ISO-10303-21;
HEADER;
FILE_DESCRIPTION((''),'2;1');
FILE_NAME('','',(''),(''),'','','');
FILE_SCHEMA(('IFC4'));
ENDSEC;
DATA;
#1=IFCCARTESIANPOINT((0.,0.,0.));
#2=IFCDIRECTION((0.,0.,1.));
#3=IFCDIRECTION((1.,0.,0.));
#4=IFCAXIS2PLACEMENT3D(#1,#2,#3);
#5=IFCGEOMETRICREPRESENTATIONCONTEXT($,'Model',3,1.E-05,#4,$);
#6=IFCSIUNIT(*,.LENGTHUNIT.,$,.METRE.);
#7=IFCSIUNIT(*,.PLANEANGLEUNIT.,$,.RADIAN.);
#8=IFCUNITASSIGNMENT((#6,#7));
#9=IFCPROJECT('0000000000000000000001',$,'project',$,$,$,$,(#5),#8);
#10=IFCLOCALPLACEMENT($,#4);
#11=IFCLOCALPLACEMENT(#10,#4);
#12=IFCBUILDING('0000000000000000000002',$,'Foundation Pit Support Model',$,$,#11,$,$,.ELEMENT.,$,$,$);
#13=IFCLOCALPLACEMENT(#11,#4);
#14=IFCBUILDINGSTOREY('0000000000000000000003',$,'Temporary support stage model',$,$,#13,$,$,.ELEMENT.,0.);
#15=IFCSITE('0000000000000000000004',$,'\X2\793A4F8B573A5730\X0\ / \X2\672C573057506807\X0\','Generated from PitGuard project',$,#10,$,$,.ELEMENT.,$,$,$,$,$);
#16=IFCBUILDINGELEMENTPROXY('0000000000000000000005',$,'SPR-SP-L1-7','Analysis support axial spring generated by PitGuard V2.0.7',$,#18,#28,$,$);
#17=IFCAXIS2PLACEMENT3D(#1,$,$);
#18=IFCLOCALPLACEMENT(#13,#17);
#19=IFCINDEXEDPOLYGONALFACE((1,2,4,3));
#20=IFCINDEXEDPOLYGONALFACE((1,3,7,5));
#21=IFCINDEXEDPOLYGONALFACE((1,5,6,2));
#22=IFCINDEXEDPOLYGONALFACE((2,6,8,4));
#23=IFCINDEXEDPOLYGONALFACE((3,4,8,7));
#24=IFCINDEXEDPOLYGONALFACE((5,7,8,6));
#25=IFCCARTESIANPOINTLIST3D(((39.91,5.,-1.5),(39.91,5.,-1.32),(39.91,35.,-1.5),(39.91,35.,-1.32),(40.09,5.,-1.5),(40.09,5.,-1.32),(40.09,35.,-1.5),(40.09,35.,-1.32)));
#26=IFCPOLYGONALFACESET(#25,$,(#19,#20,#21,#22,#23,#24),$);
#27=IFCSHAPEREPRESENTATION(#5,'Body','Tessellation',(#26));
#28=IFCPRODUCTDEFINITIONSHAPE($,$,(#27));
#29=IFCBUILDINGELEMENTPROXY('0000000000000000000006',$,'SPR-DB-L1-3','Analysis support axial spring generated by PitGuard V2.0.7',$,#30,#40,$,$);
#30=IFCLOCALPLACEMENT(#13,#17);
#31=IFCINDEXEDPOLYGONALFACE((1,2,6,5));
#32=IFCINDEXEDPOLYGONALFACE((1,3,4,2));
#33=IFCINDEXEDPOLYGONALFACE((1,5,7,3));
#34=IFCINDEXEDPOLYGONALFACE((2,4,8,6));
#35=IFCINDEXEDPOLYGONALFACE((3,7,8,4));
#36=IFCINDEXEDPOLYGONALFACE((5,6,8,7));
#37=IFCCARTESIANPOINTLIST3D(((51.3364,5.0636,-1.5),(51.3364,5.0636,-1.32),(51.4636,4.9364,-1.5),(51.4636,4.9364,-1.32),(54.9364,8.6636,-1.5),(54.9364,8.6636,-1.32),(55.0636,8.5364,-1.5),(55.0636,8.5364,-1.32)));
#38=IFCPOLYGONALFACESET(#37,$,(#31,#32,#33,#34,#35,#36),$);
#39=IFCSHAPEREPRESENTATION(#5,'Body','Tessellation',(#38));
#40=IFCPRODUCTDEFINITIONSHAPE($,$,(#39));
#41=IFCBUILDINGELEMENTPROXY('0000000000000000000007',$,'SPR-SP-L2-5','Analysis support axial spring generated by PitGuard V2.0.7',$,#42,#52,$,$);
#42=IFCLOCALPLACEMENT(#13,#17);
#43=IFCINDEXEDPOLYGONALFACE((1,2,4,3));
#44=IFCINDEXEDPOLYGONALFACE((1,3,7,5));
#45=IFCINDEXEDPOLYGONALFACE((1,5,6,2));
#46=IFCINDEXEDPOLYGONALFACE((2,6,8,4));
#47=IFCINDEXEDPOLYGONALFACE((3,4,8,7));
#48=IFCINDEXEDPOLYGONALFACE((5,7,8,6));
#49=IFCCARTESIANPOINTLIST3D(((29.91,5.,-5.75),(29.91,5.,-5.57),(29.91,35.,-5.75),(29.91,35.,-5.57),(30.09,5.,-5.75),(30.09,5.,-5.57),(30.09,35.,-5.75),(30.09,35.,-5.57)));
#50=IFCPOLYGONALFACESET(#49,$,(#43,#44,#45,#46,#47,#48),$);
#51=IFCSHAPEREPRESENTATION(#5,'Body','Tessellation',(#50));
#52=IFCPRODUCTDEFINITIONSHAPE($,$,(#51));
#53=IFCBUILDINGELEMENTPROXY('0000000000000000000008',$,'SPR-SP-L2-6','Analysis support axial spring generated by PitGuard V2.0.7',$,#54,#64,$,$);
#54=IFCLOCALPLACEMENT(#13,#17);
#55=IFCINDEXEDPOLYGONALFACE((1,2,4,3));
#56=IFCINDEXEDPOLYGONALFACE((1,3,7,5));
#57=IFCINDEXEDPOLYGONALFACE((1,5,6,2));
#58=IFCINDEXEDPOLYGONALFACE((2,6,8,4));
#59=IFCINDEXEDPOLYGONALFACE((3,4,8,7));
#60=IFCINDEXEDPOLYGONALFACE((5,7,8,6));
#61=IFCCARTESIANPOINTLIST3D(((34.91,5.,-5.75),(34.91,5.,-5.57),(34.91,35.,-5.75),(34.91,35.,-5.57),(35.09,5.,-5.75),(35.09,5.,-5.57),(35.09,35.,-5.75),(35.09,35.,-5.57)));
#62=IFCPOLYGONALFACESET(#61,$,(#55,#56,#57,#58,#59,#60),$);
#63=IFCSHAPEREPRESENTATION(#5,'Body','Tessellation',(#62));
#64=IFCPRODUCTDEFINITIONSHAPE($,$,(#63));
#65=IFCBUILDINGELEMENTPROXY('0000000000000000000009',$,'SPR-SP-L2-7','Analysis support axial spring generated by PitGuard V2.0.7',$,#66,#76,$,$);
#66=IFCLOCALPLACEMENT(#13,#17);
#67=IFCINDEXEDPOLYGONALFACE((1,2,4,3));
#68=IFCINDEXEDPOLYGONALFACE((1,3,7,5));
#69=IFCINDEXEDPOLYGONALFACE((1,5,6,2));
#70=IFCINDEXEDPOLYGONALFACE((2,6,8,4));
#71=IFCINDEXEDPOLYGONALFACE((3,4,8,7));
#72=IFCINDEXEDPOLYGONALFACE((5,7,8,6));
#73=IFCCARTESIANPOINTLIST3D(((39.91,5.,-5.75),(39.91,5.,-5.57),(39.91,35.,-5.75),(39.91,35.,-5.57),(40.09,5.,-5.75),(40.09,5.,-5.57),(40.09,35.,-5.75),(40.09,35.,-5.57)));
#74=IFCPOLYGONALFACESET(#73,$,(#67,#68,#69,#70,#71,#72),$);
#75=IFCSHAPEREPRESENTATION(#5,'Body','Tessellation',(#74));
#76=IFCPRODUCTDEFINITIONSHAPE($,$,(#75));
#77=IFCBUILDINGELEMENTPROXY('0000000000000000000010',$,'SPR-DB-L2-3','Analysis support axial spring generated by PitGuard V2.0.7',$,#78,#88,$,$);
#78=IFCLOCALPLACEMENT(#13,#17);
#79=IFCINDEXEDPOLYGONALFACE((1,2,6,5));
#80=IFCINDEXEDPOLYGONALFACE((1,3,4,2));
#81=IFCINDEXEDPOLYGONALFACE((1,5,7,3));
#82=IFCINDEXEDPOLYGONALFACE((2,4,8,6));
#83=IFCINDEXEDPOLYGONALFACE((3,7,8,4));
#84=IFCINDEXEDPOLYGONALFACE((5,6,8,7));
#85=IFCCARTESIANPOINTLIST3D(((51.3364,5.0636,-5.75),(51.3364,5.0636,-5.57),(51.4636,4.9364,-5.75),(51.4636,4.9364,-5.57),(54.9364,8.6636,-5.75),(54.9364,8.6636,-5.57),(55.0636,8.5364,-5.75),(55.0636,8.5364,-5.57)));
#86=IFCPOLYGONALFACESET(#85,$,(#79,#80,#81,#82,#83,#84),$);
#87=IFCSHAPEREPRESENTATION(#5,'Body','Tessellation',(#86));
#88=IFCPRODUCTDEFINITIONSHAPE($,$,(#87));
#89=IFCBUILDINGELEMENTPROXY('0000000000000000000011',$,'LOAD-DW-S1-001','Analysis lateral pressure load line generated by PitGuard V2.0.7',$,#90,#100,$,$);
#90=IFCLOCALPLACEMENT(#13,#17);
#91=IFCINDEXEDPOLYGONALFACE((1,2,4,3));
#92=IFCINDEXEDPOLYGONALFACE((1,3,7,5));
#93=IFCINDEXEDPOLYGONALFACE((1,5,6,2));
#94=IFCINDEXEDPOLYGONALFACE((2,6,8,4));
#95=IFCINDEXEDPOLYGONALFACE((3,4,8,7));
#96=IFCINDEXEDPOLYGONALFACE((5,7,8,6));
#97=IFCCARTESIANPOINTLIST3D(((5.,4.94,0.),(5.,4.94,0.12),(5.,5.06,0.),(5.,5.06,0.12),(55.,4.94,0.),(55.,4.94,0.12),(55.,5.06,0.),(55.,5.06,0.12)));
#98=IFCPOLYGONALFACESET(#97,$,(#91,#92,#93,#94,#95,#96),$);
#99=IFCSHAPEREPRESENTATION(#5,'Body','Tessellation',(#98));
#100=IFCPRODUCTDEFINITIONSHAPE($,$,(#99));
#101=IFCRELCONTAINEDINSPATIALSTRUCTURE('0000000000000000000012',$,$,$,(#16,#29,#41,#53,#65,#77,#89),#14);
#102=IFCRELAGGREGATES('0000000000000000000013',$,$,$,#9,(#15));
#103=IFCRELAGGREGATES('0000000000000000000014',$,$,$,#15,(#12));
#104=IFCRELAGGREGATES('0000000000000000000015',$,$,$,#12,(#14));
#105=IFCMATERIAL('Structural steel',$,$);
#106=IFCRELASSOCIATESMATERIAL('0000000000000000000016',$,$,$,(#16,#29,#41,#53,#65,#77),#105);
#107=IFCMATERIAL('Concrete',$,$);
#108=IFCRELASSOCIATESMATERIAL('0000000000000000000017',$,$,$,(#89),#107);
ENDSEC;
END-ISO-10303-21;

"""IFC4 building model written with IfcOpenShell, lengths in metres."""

from ifc_helpers import new_model, si_unit, frame, origin_with_axes, origin_2d, place, context, project, spatial, rectangle, extrude, material, element, save


model = new_model("IFC4")

# Units and contexts
model_context = context("Model", 3, precision=1e-05, world=origin_with_axes())
ifc_project = project(units=[si_unit("LENGTHUNIT", "METRE"), si_unit("PLANEANGLEUNIT", "RADIAN")], contexts=[model_context])

# Site, building, storey
site_placement = place(None, origin_with_axes())
site = spatial("IfcSite", under=ifc_project, at=site_placement, Name="示例场地 / 本地坐标", Description="Generated from PitGuard project", CompositionType="ELEMENT")
building_placement = place(site_placement, origin_with_axes())
building = spatial("IfcBuilding", under=site, at=building_placement, Name="Foundation Pit Support Model", CompositionType="ELEMENT")
storey_placement = place(building_placement, origin_with_axes())
storey = spatial("IfcBuildingStorey", under=building, at=storey_placement, Name="Temporary support stage model", CompositionType="ELEMENT", Elevation=0.0)

# Shared definitions
ifc_material_1 = material(Name="Concrete")

# Building element proxies
ifc_material_2 = material(Name="Structural steel")
for number, where, z_axis, x_axis, name in (
    (1, (40.0, 20.0, -1.5), (0.0, 0.0, 1.0), (0.0, 1.0, 0.0), "SPR-SP-L1-7"),
):
    element("IfcBuildingElementProxy", number, at=place(storey_placement, frame(where, z_axis=z_axis, x_axis=x_axis)), inside=storey, material=ifc_material_2, Name=name, Description="Analysis support axial spring generated by PitGuard V2.0.7", context=model_context, shape_type="SweptSolid", body=[
        extrude(rectangle(XDim=30.0, YDim=0.18, at=origin_2d()), origin_with_axes(), (0.0, 0.0, 1.0), 0.18),
    ])
proxy_1_placement = place(storey_placement, frame((53.2, 6.8, -1.5), z_axis=(0.0, 0.0, 1.0), x_axis=(0.707107, 0.707107, 0.0)))
element("IfcBuildingElementProxy", 2, at=proxy_1_placement, inside=storey, material=ifc_material_2, Name="SPR-DB-L1-3", Description="Analysis support axial spring generated by PitGuard V2.0.7", context=model_context, shape_type="SweptSolid", body=[
    extrude(rectangle(XDim=5.0912, YDim=0.18, at=origin_2d()), origin_with_axes(), (0.0, 0.0, 1.0), 0.18),
])
for number, where, z_axis, x_axis, name in (
    (3, (30.0, 20.0, -5.75), (0.0, 0.0, 1.0), (0.0, 1.0, 0.0), "SPR-SP-L2-5"),
    (4, (35.0, 20.0, -5.75), (0.0, 0.0, 1.0), (0.0, 1.0, 0.0), "SPR-SP-L2-6"),
    (5, (40.0, 20.0, -5.75), (0.0, 0.0, 1.0), (0.0, 1.0, 0.0), "SPR-SP-L2-7"),
):
    element("IfcBuildingElementProxy", number, at=place(storey_placement, frame(where, z_axis=z_axis, x_axis=x_axis)), inside=storey, material=ifc_material_2, Name=name, Description="Analysis support axial spring generated by PitGuard V2.0.7", context=model_context, shape_type="SweptSolid", body=[
        extrude(rectangle(XDim=30.0, YDim=0.18, at=origin_2d()), origin_with_axes(), (0.0, 0.0, 1.0), 0.18),
    ])
proxy_2_placement = place(storey_placement, frame((53.2, 6.8, -5.75), z_axis=(0.0, 0.0, 1.0), x_axis=(0.707107, 0.707107, 0.0)))
element("IfcBuildingElementProxy", 6, at=proxy_2_placement, inside=storey, material=ifc_material_2, Name="SPR-DB-L2-3", Description="Analysis support axial spring generated by PitGuard V2.0.7", context=model_context, shape_type="SweptSolid", body=[
    extrude(rectangle(XDim=5.0912, YDim=0.18, at=origin_2d()), origin_with_axes(), (0.0, 0.0, 1.0), 0.18),
])
proxy_3_placement = place(storey_placement, frame((30.0, 5.0, 0.0), z_axis=(0.0, 0.0, 1.0), x_axis=(1.0, 0.0, 0.0)))
element("IfcBuildingElementProxy", 7, at=proxy_3_placement, inside=storey, material=ifc_material_1, Name="LOAD-DW-S1-001", Description="Analysis lateral pressure load line generated by PitGuard V2.0.7", context=model_context, shape_type="SweptSolid", body=[
    extrude(rectangle(XDim=50.0, YDim=0.12, at=origin_2d()), origin_with_axes(), (0.0, 0.0, 1.0), 0.12),
])

save(model, "model.ifc")
